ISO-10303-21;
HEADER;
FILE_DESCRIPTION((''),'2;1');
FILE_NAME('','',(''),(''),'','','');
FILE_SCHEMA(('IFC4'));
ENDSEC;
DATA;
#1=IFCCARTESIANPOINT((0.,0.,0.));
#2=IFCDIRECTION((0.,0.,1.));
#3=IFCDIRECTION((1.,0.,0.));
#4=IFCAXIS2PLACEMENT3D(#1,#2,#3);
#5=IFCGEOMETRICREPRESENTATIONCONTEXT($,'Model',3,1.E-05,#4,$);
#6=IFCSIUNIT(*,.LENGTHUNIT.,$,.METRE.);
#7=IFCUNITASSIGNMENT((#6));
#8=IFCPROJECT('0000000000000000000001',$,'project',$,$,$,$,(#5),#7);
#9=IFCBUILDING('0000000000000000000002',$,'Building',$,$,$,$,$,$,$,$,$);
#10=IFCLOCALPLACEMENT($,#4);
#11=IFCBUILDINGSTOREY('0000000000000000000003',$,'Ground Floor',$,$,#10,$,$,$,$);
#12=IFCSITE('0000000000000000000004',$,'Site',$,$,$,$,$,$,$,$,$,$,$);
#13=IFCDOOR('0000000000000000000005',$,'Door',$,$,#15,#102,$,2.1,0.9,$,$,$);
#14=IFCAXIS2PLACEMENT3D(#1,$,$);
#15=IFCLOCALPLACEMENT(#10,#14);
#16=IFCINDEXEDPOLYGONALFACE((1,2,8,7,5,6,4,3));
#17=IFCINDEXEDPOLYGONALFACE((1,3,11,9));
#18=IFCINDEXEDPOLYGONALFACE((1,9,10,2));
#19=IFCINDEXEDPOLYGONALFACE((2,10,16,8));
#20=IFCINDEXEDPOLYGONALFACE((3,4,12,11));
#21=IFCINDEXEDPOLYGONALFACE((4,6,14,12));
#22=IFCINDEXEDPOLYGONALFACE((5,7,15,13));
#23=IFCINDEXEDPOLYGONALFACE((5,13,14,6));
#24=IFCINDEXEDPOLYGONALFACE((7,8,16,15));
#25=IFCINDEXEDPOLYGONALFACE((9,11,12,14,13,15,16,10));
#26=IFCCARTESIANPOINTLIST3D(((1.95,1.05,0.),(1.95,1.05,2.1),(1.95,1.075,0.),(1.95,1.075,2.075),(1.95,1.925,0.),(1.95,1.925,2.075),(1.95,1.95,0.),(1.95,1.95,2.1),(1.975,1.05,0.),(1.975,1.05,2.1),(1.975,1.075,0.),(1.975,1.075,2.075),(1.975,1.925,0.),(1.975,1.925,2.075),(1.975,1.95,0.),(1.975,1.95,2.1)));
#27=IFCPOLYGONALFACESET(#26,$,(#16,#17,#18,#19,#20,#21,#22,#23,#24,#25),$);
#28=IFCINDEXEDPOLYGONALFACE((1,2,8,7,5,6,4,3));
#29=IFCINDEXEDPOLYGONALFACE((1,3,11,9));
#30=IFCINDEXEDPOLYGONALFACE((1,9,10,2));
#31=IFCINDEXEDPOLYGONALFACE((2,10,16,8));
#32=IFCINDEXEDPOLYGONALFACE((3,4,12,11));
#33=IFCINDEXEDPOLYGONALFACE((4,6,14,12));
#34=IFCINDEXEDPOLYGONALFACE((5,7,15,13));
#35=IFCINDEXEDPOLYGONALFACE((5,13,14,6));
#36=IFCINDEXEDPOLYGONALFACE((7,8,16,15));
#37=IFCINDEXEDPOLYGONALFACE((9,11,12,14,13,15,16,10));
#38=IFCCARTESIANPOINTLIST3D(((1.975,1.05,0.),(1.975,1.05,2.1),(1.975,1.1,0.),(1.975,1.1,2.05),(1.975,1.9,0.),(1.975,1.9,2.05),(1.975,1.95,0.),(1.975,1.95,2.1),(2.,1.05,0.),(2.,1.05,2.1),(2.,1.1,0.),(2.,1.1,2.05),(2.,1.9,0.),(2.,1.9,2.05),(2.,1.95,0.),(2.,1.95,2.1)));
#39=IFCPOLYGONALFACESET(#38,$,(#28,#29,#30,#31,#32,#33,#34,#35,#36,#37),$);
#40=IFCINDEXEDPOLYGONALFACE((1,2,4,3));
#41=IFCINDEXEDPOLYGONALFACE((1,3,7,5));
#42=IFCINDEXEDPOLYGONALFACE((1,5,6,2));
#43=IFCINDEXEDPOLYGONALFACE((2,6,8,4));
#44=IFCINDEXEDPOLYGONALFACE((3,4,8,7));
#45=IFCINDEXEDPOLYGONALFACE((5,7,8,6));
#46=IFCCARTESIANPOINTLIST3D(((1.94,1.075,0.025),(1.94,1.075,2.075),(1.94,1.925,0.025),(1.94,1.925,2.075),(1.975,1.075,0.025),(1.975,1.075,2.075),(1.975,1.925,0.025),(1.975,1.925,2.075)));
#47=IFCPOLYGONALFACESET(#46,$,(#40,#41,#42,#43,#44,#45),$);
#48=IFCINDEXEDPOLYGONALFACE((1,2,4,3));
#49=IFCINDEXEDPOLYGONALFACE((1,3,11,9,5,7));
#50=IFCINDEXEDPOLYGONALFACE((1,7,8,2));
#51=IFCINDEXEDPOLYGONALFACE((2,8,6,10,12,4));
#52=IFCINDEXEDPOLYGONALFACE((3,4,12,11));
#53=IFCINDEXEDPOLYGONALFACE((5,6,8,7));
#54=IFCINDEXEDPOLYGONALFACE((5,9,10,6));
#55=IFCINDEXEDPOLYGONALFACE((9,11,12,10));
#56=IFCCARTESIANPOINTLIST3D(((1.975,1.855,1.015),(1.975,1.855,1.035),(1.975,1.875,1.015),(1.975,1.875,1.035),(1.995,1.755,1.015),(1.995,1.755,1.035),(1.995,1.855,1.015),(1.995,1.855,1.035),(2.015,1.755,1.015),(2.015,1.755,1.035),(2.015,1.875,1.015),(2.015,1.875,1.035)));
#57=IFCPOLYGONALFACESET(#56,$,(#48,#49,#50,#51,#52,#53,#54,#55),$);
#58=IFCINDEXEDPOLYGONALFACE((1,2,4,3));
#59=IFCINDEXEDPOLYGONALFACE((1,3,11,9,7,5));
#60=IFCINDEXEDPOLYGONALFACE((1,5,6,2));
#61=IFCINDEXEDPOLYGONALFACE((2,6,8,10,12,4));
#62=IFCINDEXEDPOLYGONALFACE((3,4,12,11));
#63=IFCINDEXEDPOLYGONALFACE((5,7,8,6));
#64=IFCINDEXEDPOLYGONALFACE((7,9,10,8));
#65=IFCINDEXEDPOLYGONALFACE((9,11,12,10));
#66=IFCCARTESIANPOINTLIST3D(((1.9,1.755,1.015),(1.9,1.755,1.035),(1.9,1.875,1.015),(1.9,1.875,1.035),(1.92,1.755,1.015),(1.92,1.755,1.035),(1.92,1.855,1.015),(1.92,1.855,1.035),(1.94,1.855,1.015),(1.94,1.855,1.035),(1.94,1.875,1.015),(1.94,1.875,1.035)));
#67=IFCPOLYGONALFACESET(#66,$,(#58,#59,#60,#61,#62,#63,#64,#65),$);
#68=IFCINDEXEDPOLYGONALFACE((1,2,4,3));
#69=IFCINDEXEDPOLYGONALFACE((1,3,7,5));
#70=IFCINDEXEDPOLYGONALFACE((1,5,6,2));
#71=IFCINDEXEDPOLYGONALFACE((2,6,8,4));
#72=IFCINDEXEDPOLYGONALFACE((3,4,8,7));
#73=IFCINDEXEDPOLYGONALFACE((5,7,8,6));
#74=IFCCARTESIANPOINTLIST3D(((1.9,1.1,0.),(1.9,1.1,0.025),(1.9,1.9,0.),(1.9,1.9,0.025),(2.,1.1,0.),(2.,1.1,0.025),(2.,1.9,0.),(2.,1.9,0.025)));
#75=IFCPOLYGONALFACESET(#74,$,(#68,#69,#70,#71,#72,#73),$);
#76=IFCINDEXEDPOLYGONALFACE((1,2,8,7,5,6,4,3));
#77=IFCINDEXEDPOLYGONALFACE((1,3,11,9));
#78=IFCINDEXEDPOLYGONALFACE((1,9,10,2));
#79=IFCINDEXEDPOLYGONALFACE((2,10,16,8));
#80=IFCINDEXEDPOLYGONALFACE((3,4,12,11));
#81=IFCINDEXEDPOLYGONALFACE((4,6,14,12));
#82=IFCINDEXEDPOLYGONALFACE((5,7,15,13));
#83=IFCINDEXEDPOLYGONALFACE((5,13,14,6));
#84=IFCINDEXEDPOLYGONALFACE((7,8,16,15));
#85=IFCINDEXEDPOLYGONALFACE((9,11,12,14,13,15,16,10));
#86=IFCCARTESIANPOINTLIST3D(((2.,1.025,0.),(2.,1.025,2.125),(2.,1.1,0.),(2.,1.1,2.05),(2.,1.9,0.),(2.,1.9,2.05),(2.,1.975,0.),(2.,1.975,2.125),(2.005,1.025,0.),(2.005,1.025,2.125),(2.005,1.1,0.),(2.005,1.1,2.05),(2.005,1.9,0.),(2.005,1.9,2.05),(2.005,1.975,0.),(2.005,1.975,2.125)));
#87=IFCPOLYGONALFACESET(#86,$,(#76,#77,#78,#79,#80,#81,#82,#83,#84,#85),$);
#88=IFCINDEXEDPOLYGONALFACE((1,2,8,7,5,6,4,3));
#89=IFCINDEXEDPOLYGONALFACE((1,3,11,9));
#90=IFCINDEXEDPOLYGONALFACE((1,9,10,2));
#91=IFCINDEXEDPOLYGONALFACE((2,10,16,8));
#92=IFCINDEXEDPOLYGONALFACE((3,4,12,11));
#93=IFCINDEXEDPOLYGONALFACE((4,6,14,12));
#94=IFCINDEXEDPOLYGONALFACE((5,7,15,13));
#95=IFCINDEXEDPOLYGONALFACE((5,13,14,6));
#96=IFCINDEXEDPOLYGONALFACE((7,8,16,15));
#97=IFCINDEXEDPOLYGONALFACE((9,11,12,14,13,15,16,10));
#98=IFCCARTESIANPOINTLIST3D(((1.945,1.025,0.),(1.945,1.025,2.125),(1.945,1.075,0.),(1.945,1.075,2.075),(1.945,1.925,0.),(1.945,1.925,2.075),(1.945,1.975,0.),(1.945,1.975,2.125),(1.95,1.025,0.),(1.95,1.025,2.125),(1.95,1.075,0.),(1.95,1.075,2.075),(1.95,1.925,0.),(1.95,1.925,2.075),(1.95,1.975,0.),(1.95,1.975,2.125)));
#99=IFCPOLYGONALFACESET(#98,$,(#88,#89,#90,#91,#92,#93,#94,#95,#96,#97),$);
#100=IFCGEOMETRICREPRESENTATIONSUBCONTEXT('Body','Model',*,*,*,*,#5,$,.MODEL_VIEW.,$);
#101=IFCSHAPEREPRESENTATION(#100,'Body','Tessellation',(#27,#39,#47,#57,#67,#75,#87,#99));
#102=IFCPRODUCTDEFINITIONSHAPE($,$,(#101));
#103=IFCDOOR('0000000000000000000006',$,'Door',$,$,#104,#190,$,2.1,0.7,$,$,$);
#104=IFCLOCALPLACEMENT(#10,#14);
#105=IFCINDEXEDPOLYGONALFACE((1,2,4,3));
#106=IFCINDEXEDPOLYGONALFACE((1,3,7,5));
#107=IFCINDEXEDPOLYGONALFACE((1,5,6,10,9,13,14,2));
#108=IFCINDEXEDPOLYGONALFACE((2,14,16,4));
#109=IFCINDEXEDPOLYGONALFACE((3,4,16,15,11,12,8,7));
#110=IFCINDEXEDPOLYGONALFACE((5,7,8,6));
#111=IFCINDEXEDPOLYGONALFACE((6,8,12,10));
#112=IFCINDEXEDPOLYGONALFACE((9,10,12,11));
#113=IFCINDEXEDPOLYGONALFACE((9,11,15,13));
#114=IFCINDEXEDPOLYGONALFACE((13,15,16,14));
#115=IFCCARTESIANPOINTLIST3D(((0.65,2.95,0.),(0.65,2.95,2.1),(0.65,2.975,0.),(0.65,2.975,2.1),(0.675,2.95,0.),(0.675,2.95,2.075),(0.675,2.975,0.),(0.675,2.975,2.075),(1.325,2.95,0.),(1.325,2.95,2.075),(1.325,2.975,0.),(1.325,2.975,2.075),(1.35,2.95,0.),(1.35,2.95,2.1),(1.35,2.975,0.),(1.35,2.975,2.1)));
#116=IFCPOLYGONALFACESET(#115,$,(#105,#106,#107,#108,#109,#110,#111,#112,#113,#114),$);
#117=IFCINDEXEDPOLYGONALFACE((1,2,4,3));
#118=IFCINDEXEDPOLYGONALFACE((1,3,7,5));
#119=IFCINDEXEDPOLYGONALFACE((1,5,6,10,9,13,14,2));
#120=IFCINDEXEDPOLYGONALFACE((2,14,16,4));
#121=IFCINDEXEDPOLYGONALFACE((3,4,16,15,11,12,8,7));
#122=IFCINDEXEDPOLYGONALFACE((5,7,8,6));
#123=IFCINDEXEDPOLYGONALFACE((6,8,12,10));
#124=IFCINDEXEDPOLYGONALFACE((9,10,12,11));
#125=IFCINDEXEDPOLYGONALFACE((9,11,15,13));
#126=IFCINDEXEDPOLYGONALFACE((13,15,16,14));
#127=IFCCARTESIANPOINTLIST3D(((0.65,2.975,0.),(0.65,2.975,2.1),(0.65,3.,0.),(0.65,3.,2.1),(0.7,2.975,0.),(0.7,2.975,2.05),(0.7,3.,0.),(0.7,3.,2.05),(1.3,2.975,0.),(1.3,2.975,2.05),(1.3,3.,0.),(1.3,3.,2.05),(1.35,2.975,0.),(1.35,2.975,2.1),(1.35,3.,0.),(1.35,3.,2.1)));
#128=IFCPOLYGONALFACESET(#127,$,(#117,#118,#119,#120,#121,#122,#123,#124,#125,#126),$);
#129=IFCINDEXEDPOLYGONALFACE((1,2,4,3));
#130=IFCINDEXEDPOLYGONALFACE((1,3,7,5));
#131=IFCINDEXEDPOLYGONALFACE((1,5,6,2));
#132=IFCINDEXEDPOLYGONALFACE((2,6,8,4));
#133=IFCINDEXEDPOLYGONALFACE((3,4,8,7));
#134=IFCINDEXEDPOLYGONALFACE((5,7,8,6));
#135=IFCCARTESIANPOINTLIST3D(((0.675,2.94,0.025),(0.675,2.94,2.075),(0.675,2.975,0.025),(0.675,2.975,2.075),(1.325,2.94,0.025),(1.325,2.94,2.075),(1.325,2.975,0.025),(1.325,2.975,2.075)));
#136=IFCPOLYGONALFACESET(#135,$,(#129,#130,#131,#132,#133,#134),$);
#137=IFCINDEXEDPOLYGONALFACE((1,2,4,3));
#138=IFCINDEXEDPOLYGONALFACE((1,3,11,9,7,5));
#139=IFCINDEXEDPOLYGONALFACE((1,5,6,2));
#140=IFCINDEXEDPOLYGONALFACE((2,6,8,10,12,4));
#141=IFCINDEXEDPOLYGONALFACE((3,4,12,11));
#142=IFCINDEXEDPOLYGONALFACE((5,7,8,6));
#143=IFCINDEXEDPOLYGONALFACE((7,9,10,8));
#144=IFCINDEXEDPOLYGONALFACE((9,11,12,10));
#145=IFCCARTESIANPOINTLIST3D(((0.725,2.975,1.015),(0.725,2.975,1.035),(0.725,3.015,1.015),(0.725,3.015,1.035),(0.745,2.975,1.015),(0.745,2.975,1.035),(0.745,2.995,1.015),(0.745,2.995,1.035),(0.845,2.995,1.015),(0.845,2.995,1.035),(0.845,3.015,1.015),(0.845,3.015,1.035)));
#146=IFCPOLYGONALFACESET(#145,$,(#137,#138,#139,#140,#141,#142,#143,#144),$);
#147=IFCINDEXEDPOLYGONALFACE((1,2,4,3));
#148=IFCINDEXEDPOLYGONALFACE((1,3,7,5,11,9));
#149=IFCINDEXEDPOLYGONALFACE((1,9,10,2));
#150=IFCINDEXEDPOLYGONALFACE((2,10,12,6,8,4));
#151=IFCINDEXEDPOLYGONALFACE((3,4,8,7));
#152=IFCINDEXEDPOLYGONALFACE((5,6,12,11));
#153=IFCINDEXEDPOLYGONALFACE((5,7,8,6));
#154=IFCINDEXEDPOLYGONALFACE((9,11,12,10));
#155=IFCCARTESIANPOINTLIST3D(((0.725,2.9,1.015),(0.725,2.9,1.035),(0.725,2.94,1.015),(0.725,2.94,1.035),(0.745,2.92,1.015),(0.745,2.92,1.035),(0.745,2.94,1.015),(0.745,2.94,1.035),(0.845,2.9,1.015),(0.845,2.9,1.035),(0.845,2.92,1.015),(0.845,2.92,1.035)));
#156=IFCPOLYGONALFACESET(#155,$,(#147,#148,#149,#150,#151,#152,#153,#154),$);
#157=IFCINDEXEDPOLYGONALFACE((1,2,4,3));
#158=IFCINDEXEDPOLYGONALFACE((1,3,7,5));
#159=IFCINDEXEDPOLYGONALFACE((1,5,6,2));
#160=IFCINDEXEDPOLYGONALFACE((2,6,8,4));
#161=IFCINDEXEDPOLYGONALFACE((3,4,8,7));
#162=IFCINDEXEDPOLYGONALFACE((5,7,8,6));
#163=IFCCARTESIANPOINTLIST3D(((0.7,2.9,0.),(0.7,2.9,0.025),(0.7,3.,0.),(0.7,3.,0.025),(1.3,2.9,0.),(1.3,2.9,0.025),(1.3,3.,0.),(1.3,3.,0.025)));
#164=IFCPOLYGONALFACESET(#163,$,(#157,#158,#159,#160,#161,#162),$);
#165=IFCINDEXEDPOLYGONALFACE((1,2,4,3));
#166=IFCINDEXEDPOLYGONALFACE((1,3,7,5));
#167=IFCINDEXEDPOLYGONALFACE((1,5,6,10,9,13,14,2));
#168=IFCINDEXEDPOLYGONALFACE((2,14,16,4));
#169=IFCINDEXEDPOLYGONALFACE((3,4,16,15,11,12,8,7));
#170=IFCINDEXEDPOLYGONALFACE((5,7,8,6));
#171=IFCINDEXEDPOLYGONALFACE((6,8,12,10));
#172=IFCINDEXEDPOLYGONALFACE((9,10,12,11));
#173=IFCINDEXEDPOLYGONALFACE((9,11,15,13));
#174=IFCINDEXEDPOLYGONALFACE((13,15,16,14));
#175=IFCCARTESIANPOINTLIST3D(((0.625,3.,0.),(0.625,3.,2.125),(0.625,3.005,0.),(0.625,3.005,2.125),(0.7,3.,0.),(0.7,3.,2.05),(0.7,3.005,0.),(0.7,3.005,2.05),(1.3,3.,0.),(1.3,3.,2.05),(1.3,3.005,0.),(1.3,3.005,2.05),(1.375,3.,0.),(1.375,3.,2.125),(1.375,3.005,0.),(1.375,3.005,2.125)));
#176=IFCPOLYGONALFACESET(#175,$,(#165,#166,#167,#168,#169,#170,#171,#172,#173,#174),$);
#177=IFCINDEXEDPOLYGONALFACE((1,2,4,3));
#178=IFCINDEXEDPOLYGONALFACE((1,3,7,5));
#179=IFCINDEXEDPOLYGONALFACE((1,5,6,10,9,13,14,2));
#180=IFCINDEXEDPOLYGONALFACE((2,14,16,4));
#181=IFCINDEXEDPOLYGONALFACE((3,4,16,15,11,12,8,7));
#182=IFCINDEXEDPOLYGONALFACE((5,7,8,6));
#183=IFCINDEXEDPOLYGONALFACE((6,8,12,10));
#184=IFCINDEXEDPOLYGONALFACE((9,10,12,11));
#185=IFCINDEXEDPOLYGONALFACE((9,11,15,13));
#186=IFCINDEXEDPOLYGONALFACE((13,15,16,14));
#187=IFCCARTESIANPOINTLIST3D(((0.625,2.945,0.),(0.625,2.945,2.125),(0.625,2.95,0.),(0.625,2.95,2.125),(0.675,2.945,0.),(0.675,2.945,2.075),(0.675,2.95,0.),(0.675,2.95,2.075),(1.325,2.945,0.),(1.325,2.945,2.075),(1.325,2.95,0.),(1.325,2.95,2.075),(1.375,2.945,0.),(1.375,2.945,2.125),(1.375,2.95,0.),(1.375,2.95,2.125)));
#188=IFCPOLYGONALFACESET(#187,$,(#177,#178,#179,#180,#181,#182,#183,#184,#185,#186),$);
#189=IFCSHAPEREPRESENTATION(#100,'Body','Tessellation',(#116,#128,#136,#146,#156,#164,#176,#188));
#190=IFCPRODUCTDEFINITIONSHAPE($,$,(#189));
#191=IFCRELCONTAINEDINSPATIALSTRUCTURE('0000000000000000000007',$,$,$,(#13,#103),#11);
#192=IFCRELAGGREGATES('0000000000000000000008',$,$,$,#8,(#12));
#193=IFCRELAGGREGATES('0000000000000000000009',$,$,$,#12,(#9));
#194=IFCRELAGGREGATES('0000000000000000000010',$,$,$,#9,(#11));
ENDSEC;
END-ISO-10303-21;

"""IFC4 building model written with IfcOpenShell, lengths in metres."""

from ifc_helpers import new_model, si_unit, frame, origin_with_axes, place, context, subcontext, project, spatial, line, indexed_curve, outline, extrude, element, save


model = new_model("IFC4")

# Units and contexts
model_context = context("Model", 3, precision=1e-05, world=origin_with_axes())
body_context = subcontext(model_context, "Body", "Model", "MODEL_VIEW")
ifc_project = project(units=[si_unit("LENGTHUNIT", "METRE")], contexts=[model_context])

# Site, building, storey
site = spatial("IfcSite", under=ifc_project, Name="Site")
building = spatial("IfcBuilding", under=site, Name="Building")
storey_placement = place(None, origin_with_axes())
storey = spatial("IfcBuildingStorey", under=building, at=storey_placement, Name="Ground Floor")

# Doors
door_1_placement = place(storey_placement, frame((2.0, 1.05, 0.0), z_axis=(0.0, 0.0, 1.0), x_axis=(0.0, 1.0, 0.0)))
element("IfcDoor", 1, at=door_1_placement, inside=storey, Name="Door", OverallHeight=2.1, OverallWidth=0.9, context=body_context, shape_type="SweptSolid", body=[
    extrude(outline(indexed_curve([(0.0, 0.0), (0.0, 2.1), (0.9, 2.1), (0.9, 0.0), (0.875, 0.0), (0.875, 2.075), (0.025, 2.075), (0.025, 0.0)], segments=[line(1, 2, 3, 4, 5, 6, 7, 8, 1)])), frame((0.0, 0.025, 0.0), z_axis=(0.0, -1.0, 0.0), x_axis=(1.0, 0.0, 0.0)), (0.0, 0.0, -1.0), 0.025),
    extrude(outline(indexed_curve([(0.0, 0.0), (0.0, 2.1), (0.9, 2.1), (0.9, 0.0), (0.85, 0.0), (0.85, 2.05), (0.05, 2.05), (0.05, 0.0)], segments=[line(1, 2, 3, 4, 5, 6, 7, 8, 1)])), frame((0.0, 0.0, 0.0), z_axis=(0.0, -1.0, 0.0), x_axis=(1.0, 0.0, 0.0)), (0.0, 0.0, -1.0), 0.025),
    extrude(outline(indexed_curve([(0.0, 0.0), (0.85, 0.0), (0.85, 0.035), (0.0, 0.035)], segments=[line(1, 2, 3, 4, 1)])), frame((0.025, 0.025, 0.025), z_axis=(0.0, 0.0, 1.0), x_axis=(1.0, 0.0, 0.0)), (0.0, 0.0, 1.0), 2.05),
    extrude(outline(indexed_curve([(0.0, 0.0), (0.0, -0.04), (-0.12, -0.04), (-0.12, -0.02), (-0.02, -0.02), (-0.02, 0.0)], segments=[line(1, 2, 3, 4, 5, 6, 1)])), frame((0.825, 0.025, 1.015), z_axis=(0.0, 0.0, 1.0), x_axis=(1.0, 0.0, 0.0)), (0.0, 0.0, 1.0), 0.02),
    extrude(outline(indexed_curve([(0.0, 0.0), (0.0, 0.04), (-0.12, 0.04), (-0.12, 0.02), (-0.02, 0.02), (-0.02, 0.0)], segments=[line(1, 2, 3, 4, 5, 6, 1)])), frame((0.825, 0.06, 1.015), z_axis=(0.0, 0.0, 1.0), x_axis=(1.0, 0.0, 0.0)), (0.0, 0.0, 1.0), 0.02),
    extrude(outline(indexed_curve([(0.0, 0.0), (0.8, 0.0), (0.8, 0.1), (0.0, 0.1)], segments=[line(1, 2, 3, 4, 1)])), frame((0.05, 0.0, 0.0), z_axis=(0.0, 0.0, 1.0), x_axis=(1.0, 0.0, 0.0)), (0.0, 0.0, 1.0), 0.025),
    extrude(outline(indexed_curve([(0.0, 0.0), (0.0, 2.125), (0.95, 2.125), (0.95, 0.0), (0.875, 0.0), (0.875, 2.05), (0.075, 2.05), (0.075, 0.0)], segments=[line(1, 2, 3, 4, 5, 6, 7, 8, 1)])), frame((-0.025, -0.005, 0.0), z_axis=(0.0, -1.0, 0.0), x_axis=(1.0, 0.0, 0.0)), (0.0, 0.0, -1.0), 0.005),
    extrude(outline(indexed_curve([(0.0, 0.0), (0.0, 2.125), (0.95, 2.125), (0.95, 0.0), (0.9, 0.0), (0.9, 2.075), (0.05, 2.075), (0.05, 0.0)], segments=[line(1, 2, 3, 4, 5, 6, 7, 8, 1)])), frame((-0.025, 0.05, 0.0), z_axis=(0.0, -1.0, 0.0), x_axis=(1.0, 0.0, 0.0)), (0.0, 0.0, -1.0), 0.005),
])
door_2_placement = place(storey_placement, frame((1.35, 3.0, 0.0), z_axis=(0.0, 0.0, 1.0), x_axis=(-1.0, 0.0, 0.0)))
element("IfcDoor", 2, at=door_2_placement, inside=storey, Name="Door", OverallHeight=2.1, OverallWidth=0.7, context=body_context, shape_type="SweptSolid", body=[
    extrude(outline(indexed_curve([(0.0, 0.0), (0.0, 2.1), (0.7, 2.1), (0.7, 0.0), (0.675, 0.0), (0.675, 2.075), (0.025, 2.075), (0.025, 0.0)], segments=[line(1, 2, 3, 4, 5, 6, 7, 8, 1)])), frame((0.0, 0.025, 0.0), z_axis=(0.0, -1.0, 0.0), x_axis=(1.0, 0.0, 0.0)), (0.0, 0.0, -1.0), 0.025),
    extrude(outline(indexed_curve([(0.0, 0.0), (0.0, 2.1), (0.7, 2.1), (0.7, 0.0), (0.65, 0.0), (0.65, 2.05), (0.05, 2.05), (0.05, 0.0)], segments=[line(1, 2, 3, 4, 5, 6, 7, 8, 1)])), frame((0.0, 0.0, 0.0), z_axis=(0.0, -1.0, 0.0), x_axis=(1.0, 0.0, 0.0)), (0.0, 0.0, -1.0), 0.025),
    extrude(outline(indexed_curve([(0.0, 0.0), (0.65, 0.0), (0.65, 0.035), (0.0, 0.035)], segments=[line(1, 2, 3, 4, 1)])), frame((0.025, 0.025, 0.025), z_axis=(0.0, 0.0, 1.0), x_axis=(1.0, 0.0, 0.0)), (0.0, 0.0, 1.0), 2.05),
    extrude(outline(indexed_curve([(0.0, 0.0), (0.0, -0.04), (-0.12, -0.04), (-0.12, -0.02), (-0.02, -0.02), (-0.02, 0.0)], segments=[line(1, 2, 3, 4, 5, 6, 1)])), frame((0.625, 0.025, 1.015), z_axis=(0.0, 0.0, 1.0), x_axis=(1.0, 0.0, 0.0)), (0.0, 0.0, 1.0), 0.02),
    extrude(outline(indexed_curve([(0.0, 0.0), (0.0, 0.04), (-0.12, 0.04), (-0.12, 0.02), (-0.02, 0.02), (-0.02, 0.0)], segments=[line(1, 2, 3, 4, 5, 6, 1)])), frame((0.625, 0.06, 1.015), z_axis=(0.0, 0.0, 1.0), x_axis=(1.0, 0.0, 0.0)), (0.0, 0.0, 1.0), 0.02),
    extrude(outline(indexed_curve([(0.0, 0.0), (0.6, 0.0), (0.6, 0.1), (0.0, 0.1)], segments=[line(1, 2, 3, 4, 1)])), frame((0.05, 0.0, 0.0), z_axis=(0.0, 0.0, 1.0), x_axis=(1.0, 0.0, 0.0)), (0.0, 0.0, 1.0), 0.025),
    extrude(outline(indexed_curve([(0.0, 0.0), (0.0, 2.125), (0.75, 2.125), (0.75, 0.0), (0.675, 0.0), (0.675, 2.05), (0.075, 2.05), (0.075, 0.0)], segments=[line(1, 2, 3, 4, 5, 6, 7, 8, 1)])), frame((-0.025, -0.005, 0.0), z_axis=(0.0, -1.0, 0.0), x_axis=(1.0, 0.0, 0.0)), (0.0, 0.0, -1.0), 0.005),
    extrude(outline(indexed_curve([(0.0, 0.0), (0.0, 2.125), (0.75, 2.125), (0.75, 0.0), (0.7, 0.0), (0.7, 2.075), (0.05, 2.075), (0.05, 0.0)], segments=[line(1, 2, 3, 4, 5, 6, 7, 8, 1)])), frame((-0.025, 0.05, 0.0), z_axis=(0.0, -1.0, 0.0), x_axis=(1.0, 0.0, 0.0)), (0.0, 0.0, -1.0), 0.005),
])

save(model, "model.ifc")
